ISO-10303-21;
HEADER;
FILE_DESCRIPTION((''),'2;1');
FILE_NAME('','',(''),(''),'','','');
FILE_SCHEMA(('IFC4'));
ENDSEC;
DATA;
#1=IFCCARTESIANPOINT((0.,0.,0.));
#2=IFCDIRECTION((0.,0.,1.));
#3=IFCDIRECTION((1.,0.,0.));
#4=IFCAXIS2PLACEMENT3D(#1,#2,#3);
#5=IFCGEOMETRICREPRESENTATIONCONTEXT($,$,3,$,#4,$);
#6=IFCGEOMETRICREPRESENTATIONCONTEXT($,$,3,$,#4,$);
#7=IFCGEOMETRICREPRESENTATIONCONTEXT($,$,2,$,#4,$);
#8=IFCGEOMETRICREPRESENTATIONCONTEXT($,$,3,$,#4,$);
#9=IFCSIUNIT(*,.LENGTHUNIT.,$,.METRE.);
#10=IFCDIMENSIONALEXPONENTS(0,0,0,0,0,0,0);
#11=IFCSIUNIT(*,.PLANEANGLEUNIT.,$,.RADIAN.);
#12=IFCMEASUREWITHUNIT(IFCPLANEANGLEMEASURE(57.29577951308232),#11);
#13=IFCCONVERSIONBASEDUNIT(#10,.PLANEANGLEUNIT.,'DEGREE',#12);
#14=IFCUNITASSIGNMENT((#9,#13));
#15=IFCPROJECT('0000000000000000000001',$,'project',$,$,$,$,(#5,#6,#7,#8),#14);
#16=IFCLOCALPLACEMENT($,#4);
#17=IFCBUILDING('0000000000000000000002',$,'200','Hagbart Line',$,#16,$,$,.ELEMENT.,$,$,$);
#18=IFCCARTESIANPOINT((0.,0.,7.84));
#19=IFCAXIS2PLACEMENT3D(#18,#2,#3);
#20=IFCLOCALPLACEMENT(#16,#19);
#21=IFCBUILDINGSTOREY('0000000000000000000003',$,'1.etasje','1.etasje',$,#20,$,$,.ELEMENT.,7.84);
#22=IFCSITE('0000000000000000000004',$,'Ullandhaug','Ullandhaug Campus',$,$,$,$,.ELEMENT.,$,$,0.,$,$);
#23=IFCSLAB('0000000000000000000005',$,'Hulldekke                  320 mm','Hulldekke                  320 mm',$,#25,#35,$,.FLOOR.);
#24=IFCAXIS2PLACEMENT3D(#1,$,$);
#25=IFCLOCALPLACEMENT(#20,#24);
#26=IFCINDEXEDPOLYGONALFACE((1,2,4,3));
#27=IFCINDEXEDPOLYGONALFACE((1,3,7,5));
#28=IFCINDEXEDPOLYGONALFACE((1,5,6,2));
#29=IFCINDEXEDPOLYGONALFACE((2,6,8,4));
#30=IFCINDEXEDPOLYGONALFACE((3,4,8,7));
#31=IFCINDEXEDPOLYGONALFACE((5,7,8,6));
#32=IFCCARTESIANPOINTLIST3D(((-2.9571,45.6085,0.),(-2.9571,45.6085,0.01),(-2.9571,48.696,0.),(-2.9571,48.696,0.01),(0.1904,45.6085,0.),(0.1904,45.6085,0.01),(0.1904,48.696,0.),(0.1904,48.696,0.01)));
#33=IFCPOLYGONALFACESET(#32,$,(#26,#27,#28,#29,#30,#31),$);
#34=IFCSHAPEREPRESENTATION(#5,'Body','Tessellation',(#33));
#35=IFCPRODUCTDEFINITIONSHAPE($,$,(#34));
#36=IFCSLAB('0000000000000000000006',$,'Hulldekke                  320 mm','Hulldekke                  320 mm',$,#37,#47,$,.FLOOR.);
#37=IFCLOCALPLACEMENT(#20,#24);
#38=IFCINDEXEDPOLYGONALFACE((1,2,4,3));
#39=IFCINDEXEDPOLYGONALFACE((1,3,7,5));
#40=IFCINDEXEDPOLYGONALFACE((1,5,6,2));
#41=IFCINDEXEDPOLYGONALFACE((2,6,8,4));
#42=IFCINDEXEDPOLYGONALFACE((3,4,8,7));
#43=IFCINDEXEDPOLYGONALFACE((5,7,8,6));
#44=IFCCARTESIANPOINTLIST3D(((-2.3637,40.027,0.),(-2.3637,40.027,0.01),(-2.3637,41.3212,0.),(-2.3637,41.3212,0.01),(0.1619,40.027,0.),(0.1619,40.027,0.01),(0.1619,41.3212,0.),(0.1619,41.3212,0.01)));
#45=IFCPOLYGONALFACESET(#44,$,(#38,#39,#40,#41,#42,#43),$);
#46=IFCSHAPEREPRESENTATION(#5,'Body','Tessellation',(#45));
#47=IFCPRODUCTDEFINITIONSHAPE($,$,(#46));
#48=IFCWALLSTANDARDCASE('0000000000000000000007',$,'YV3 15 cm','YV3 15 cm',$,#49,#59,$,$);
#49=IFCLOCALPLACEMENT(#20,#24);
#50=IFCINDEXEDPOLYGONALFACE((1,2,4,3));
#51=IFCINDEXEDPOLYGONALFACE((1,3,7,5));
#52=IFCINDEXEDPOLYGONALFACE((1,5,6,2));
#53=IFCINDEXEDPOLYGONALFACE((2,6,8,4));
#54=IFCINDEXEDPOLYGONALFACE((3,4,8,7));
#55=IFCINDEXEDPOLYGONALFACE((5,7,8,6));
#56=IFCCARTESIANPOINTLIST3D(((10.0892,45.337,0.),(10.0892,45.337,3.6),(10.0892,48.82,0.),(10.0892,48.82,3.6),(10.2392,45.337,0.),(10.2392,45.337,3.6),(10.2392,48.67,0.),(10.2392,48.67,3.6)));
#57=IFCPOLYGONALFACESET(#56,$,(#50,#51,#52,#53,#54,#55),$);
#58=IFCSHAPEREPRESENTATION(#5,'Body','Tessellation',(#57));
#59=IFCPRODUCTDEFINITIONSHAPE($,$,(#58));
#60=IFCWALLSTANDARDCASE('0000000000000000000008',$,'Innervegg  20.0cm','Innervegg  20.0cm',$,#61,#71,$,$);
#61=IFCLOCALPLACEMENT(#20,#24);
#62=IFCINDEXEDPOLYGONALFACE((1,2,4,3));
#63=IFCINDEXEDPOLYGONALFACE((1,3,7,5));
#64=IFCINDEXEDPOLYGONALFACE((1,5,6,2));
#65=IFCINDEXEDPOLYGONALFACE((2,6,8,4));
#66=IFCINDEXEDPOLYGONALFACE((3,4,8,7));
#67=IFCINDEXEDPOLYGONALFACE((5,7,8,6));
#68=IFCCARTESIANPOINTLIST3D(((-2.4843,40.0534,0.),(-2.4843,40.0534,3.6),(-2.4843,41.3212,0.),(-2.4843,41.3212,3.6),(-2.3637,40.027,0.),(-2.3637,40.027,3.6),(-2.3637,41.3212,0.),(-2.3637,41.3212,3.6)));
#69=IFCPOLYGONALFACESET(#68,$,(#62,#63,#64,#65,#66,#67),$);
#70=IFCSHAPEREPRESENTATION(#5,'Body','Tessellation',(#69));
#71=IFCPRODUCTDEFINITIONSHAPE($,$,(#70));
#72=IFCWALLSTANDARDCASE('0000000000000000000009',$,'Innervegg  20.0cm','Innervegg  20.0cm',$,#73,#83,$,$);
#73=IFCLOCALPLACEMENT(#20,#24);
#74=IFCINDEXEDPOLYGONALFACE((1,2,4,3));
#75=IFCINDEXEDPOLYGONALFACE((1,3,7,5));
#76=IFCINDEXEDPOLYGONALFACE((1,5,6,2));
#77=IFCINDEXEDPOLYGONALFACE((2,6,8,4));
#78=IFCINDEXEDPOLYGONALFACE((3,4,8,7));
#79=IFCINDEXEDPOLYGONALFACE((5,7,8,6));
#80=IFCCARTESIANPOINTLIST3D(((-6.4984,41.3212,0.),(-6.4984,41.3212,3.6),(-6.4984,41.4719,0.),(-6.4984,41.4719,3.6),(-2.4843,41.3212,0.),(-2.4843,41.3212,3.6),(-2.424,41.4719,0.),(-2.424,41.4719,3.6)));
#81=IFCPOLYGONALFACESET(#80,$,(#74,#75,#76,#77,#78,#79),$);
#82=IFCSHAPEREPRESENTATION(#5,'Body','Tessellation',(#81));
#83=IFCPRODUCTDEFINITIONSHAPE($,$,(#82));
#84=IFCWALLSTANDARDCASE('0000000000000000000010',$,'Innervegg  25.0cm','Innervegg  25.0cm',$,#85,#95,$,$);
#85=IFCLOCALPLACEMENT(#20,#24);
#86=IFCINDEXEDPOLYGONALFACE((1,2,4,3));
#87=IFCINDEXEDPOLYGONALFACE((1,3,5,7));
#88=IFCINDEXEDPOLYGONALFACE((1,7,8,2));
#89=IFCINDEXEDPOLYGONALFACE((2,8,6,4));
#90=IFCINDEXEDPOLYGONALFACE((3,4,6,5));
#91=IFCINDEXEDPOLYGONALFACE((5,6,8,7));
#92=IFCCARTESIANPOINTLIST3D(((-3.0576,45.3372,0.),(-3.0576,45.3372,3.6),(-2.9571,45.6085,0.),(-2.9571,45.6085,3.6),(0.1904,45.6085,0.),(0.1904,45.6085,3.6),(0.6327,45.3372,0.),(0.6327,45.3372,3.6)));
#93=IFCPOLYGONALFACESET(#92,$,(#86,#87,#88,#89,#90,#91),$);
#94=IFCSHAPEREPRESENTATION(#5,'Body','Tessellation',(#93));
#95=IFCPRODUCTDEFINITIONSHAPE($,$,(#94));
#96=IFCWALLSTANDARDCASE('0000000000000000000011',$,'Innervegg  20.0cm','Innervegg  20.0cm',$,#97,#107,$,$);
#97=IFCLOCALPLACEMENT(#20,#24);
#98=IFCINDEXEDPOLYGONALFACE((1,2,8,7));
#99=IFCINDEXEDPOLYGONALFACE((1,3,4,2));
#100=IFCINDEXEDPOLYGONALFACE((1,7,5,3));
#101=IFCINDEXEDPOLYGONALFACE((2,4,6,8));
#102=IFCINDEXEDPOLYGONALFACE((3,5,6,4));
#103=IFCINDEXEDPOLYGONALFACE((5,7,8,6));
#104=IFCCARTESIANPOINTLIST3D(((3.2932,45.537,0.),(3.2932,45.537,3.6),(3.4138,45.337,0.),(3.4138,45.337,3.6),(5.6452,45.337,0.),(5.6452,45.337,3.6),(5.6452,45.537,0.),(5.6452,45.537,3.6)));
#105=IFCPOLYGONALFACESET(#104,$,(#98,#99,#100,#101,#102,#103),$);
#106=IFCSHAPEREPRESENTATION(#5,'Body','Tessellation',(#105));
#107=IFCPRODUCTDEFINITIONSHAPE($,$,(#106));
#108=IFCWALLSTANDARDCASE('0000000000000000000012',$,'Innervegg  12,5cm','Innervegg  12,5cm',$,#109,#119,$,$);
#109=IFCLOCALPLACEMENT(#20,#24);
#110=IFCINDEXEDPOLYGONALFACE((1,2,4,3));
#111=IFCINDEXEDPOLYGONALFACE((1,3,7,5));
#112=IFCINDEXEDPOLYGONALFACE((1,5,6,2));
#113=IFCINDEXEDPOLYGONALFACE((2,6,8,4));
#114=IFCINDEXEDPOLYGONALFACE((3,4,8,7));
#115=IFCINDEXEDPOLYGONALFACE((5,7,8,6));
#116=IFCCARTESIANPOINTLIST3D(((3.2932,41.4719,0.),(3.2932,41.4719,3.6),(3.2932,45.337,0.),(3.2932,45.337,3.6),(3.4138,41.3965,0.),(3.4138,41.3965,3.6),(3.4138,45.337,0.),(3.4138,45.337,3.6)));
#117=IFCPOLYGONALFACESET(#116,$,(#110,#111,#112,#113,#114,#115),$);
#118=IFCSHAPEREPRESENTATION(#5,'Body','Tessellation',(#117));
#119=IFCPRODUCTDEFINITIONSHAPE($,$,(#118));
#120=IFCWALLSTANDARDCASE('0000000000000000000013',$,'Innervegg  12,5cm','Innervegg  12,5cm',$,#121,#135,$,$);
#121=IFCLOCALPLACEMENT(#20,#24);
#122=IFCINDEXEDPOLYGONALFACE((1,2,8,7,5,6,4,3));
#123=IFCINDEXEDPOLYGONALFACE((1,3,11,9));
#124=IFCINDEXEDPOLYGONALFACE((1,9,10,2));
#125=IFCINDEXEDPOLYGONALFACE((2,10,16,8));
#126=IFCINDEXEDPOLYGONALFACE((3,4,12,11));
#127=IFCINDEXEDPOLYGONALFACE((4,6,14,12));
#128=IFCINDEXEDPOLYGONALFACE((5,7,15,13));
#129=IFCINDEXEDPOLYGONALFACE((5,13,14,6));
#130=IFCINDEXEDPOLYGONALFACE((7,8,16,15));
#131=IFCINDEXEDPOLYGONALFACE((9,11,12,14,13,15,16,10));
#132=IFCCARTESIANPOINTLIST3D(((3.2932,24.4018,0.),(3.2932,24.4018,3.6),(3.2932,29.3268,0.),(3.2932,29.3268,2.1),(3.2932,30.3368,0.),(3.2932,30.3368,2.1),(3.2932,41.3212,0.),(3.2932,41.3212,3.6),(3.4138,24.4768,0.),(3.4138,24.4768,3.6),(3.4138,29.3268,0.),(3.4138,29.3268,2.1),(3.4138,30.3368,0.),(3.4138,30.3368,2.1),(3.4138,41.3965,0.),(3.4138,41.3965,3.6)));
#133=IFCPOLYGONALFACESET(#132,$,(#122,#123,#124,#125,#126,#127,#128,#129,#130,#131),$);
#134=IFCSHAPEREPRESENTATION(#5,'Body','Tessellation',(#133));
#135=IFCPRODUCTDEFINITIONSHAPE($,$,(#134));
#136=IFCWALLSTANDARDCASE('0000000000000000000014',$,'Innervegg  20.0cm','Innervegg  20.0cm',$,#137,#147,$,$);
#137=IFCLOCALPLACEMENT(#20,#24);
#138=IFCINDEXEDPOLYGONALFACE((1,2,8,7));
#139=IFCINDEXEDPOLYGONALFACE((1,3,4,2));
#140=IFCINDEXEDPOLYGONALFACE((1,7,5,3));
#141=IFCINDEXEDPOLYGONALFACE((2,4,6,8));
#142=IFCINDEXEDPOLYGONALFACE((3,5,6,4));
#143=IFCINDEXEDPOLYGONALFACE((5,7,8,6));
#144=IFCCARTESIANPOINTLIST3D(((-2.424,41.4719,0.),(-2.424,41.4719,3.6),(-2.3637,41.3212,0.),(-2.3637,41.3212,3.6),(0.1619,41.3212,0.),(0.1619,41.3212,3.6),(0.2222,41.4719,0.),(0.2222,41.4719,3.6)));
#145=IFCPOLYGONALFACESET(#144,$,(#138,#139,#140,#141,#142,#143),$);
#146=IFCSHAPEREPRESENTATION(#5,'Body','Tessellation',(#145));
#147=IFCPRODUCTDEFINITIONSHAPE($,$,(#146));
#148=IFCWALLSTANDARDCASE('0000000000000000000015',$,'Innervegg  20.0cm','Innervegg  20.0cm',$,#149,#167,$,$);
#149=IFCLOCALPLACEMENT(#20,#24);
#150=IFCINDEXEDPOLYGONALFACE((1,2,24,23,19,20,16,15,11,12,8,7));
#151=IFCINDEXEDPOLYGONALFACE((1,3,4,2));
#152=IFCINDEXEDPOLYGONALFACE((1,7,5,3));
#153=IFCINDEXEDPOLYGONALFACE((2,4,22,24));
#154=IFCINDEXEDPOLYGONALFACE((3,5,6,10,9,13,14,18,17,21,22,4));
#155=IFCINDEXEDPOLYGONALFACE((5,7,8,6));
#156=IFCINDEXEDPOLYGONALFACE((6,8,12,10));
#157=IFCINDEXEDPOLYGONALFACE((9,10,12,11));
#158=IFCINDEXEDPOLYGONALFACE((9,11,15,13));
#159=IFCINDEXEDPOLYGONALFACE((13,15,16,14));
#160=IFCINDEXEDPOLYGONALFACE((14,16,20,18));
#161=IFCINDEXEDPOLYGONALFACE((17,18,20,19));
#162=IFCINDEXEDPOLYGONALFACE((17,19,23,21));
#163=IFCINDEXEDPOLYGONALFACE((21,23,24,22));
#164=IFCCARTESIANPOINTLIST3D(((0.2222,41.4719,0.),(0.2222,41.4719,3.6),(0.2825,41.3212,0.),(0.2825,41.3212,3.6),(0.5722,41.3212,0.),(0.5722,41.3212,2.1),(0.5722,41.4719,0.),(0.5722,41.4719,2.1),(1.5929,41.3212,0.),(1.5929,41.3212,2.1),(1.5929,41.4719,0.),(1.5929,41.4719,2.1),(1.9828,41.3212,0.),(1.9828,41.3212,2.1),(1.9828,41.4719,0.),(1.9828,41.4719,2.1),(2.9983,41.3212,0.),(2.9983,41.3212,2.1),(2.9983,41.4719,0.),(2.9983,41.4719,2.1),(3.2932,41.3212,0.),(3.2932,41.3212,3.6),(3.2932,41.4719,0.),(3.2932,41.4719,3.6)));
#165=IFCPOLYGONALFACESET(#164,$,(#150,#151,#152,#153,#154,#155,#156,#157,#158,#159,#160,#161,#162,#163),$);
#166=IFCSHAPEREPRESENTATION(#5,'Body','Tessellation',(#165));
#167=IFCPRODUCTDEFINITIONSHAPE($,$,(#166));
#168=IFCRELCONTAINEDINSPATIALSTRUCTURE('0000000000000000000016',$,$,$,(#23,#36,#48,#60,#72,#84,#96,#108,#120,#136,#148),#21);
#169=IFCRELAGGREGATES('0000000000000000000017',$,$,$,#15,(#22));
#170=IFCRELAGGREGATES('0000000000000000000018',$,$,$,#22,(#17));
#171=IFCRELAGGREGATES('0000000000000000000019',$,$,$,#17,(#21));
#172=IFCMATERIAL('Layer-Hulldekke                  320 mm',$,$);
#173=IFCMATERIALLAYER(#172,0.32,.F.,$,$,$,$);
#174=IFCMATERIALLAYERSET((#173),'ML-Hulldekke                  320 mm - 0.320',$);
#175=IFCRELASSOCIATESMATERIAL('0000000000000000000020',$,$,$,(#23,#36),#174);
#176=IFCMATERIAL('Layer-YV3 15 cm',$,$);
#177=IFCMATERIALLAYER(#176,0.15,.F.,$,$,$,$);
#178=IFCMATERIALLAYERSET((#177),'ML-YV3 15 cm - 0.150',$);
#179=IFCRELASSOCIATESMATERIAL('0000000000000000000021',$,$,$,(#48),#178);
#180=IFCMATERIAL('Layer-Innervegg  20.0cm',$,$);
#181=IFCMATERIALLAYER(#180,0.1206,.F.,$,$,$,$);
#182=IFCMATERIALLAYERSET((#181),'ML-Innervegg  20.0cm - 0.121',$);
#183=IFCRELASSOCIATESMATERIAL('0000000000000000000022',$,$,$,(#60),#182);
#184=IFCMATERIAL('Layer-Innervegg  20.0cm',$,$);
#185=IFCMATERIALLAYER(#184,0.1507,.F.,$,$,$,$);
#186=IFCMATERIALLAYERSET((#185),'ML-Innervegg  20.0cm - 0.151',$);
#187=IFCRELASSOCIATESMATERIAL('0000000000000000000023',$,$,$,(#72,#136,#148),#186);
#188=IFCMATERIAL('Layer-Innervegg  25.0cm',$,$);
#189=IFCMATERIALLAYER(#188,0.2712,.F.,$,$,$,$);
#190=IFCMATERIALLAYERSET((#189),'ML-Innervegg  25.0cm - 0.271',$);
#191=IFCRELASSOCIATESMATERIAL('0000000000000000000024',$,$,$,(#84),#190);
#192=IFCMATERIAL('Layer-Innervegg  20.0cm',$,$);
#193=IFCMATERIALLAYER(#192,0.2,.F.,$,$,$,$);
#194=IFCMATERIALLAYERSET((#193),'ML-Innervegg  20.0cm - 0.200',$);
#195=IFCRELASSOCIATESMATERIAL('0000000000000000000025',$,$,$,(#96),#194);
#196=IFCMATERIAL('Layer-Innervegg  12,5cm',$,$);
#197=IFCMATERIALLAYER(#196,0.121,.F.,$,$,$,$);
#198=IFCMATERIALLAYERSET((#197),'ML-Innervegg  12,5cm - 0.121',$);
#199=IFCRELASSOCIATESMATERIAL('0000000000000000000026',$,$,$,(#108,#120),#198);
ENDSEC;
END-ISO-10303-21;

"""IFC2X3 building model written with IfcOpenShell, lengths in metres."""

from ifc_helpers import new_model, entity, si_unit, converted_unit, frame, origin_with_axes, place, context, project, spatial, polyline, outline, extrude, material, layer, layer_set, layer_usage, element, save


model = new_model("IFC2X3")

# Units and contexts
context_of_model_1 = context(None, 3, world=origin_with_axes())
context_of_model_2 = context(None, 3, world=origin_with_axes())
context_of_model_3 = context(None, 2, world=origin_with_axes())
context_of_model_4 = context(None, 3, world=origin_with_axes())
ifc_project = project(units=[si_unit("LENGTHUNIT", "METRE"), converted_unit("PLANEANGLEUNIT", "DEGREE", entity("IfcPlaneAngleMeasure", 57.29577951308232), si_unit("PLANEANGLEUNIT", "RADIAN"), dimensions=[0, 0, 0, 0, 0, 0, 0])], contexts=[context_of_model_1, context_of_model_2, context_of_model_3, context_of_model_4])

# Site, building, storey
site = spatial("IfcSite", under=ifc_project, Name="Ullandhaug", Description="Ullandhaug Campus", CompositionType="ELEMENT", RefElevation=0.0)
building_placement = place(None, origin_with_axes())
building = spatial("IfcBuilding", under=site, at=building_placement, Name="200", Description="Hagbart Line", CompositionType="ELEMENT")
storey_placement = place(building_placement, frame((0.0, 0.0, 7.84), z_axis=(0.0, 0.0, 1.0), x_axis=(1.0, 0.0, 0.0)))
storey = spatial("IfcBuildingStorey", under=building, at=storey_placement, Name="1.etasje", Description="1.etasje", CompositionType="ELEMENT", Elevation=7.84)

# Slabs
ifc_material_1 = material(Name="Layer-Hulldekke                  320 mm")
ifc_layer_1 = layer(ifc_material_1, 0.32, ventilated=False)
ifc_layer_set_1 = layer_set([ifc_layer_1], Name="ML-Hulldekke                  320 mm - 0.320")
ifc_layer_usage_1 = layer_usage(ifc_layer_set_1, "AXIS2", "POSITIVE", 0.0)
slab_1_placement = place(storey_placement, frame((-2.9571, 45.6085, 0.0), z_axis=(0.0, 0.0, 1.0), x_axis=(1.0, 0.0, 0.0)))
element("IfcSlab", 1, at=slab_1_placement, inside=storey, material=ifc_layer_usage_1, Name="Hulldekke                  320 mm", Description="Hulldekke                  320 mm", PredefinedType="FLOOR", context=context_of_model_1, shape_type="SweptSolid", body=[
    extrude(outline(polyline([(0.0, 0.0), (3.1475, 0.0), (3.1475, 3.0875), (0.0, 3.0875), (0.0, 0.0)])), origin_with_axes(), (0.0, 0.0, 1.0), 0.01),
])
slab_2_placement = place(storey_placement, frame((-2.3637, 40.027, 0.0), z_axis=(0.0, 0.0, 1.0), x_axis=(1.0, 0.0, 0.0)))
element("IfcSlab", 2, at=slab_2_placement, inside=storey, material=ifc_layer_usage_1, Name="Hulldekke                  320 mm", Description="Hulldekke                  320 mm", PredefinedType="FLOOR", context=context_of_model_1, shape_type="SweptSolid", body=[
    extrude(outline(polyline([(0.0, 0.0), (2.5256, 0.0), (2.5256, 1.2942), (0.0, 1.2942), (0.0, 0.0)])), origin_with_axes(), (0.0, 0.0, 1.0), 0.01),
])

# Walls
ifc_material_2 = material(Name="Layer-YV3 15 cm")
ifc_layer_2 = layer(ifc_material_2, 0.15, ventilated=False)
ifc_layer_set_2 = layer_set([ifc_layer_2], Name="ML-YV3 15 cm - 0.150")
ifc_layer_usage_2 = layer_usage(ifc_layer_set_2, "AXIS2", "POSITIVE", 0.0)
wall_1_placement = place(storey_placement, frame((10.2392, 45.337, 0.0), z_axis=(0.0, 0.0, 1.0), x_axis=(0.0, 1.0, 0.0)))
element("IfcWallStandardCase", 3, at=wall_1_placement, inside=storey, material=ifc_layer_usage_2, Name="YV3 15 cm", Description="YV3 15 cm", context=context_of_model_1, shape_type="SweptSolid", body=[
    extrude(outline(polyline([(0.0, 0.0), (3.333, 0.0), (3.483, 0.15), (0.0, 0.15), (0.0, 0.0)])), frame((0.0, 0.0, 0.0), z_axis=(0.0, 0.0, 1.0), x_axis=(1.0, 0.0, 0.0)), (0.0, 0.0, 1.0), 3.6),
])
ifc_material_3 = material(Name="Layer-Innervegg  20.0cm")
ifc_layer_3 = layer(ifc_material_3, 0.1206, ventilated=False)
ifc_layer_set_3 = layer_set([ifc_layer_3], Name="ML-Innervegg  20.0cm - 0.121")
ifc_layer_usage_3 = layer_usage(ifc_layer_set_3, "AXIS2", "POSITIVE", 0.0)
wall_2_placement = place(storey_placement, frame((-2.3637, 40.027, 0.0), z_axis=(0.0, 0.0, 1.0), x_axis=(0.0, 1.0, 0.0)))
element("IfcWallStandardCase", 4, at=wall_2_placement, inside=storey, material=ifc_layer_usage_3, Name="Innervegg  20.0cm", Description="Innervegg  20.0cm", context=context_of_model_1, shape_type="SweptSolid", body=[
    extrude(outline(polyline([(0.0, 0.0), (1.2942, 0.0), (1.2942, 0.1206), (0.0264, 0.1206), (0.0, 0.0)])), frame((0.0, 0.0, 0.0), z_axis=(0.0, 0.0, 1.0), x_axis=(1.0, 0.0, 0.0)), (0.0, 0.0, 1.0), 3.6),
])
ifc_material_4 = material(Name="Layer-Innervegg  20.0cm")
ifc_layer_4 = layer(ifc_material_4, 0.1507, ventilated=False)
ifc_layer_set_4 = layer_set([ifc_layer_4], Name="ML-Innervegg  20.0cm - 0.151")
ifc_layer_usage_4 = layer_usage(ifc_layer_set_4, "AXIS2", "POSITIVE", 0.0)
wall_3_placement = place(storey_placement, frame((-2.424, 41.4719, 0.0), z_axis=(0.0, 0.0, 1.0), x_axis=(-1.0, 0.0, 0.0)))
element("IfcWallStandardCase", 5, at=wall_3_placement, inside=storey, material=ifc_layer_usage_4, Name="Innervegg  20.0cm", Description="Innervegg  20.0cm", context=context_of_model_1, shape_type="SweptSolid", body=[
    extrude(outline(polyline([(0.0, 0.0), (4.0744, 0.0), (4.0744, 0.1507), (0.0603, 0.1507), (0.0, 0.0)])), frame((0.0, 0.0, 0.0), z_axis=(0.0, 0.0, 1.0), x_axis=(1.0, 0.0, 0.0)), (0.0, 0.0, 1.0), 3.6),
])
ifc_material_5 = material(Name="Layer-Innervegg  25.0cm")
ifc_layer_5 = layer(ifc_material_5, 0.2712, ventilated=False)
ifc_layer_set_5 = layer_set([ifc_layer_5], Name="ML-Innervegg  25.0cm - 0.271")
ifc_layer_usage_5 = layer_usage(ifc_layer_set_5, "AXIS2", "POSITIVE", 0.0)
wall_4_placement = place(storey_placement, frame((-3.0576, 45.3372, 0.0), z_axis=(0.0, 0.0, 1.0), x_axis=(1.0, 0.0, 0.0)))
element("IfcWallStandardCase", 6, at=wall_4_placement, inside=storey, material=ifc_layer_usage_5, Name="Innervegg  25.0cm", Description="Innervegg  25.0cm", context=context_of_model_1, shape_type="SweptSolid", body=[
    extrude(outline(polyline([(0.0, 0.0), (3.6903, 0.0), (3.248, 0.2712), (0.1005, 0.2712), (0.0, 0.0)])), origin_with_axes(), (0.0, 0.0, 1.0), 3.6),
])
ifc_material_6 = material(Name="Layer-Innervegg  20.0cm")
ifc_layer_6 = layer(ifc_material_6, 0.2, ventilated=False)
ifc_layer_set_6 = layer_set([ifc_layer_6], Name="ML-Innervegg  20.0cm - 0.200")
ifc_layer_usage_6 = layer_usage(ifc_layer_set_6, "AXIS2", "POSITIVE", 0.0)
wall_5_placement = place(storey_placement, frame((5.6452, 45.537, 0.0), z_axis=(0.0, 0.0, 1.0), x_axis=(-1.0, 0.0, 0.0)))
element("IfcWallStandardCase", 7, at=wall_5_placement, inside=storey, material=ifc_layer_usage_6, Name="Innervegg  20.0cm", Description="Innervegg  20.0cm", context=context_of_model_1, shape_type="SweptSolid", body=[
    extrude(outline(polyline([(0.0, 0.0), (2.3521, 0.0), (2.2315, 0.2), (0.0, 0.2), (0.0, 0.0)])), frame((0.0, 0.0, 0.0), z_axis=(0.0, 0.0, 1.0), x_axis=(1.0, 0.0, 0.0)), (0.0, 0.0, 1.0), 3.6),
])
ifc_material_7 = material(Name="Layer-Innervegg  12,5cm")
ifc_layer_7 = layer(ifc_material_7, 0.121, ventilated=False)
ifc_layer_set_7 = layer_set([ifc_layer_7], Name="ML-Innervegg  12,5cm - 0.121")
ifc_layer_usage_7 = layer_usage(ifc_layer_set_7, "AXIS2", "POSITIVE", 0.0)
wall_6_placement = place(storey_placement, frame((3.2932, 45.337, 0.0), z_axis=(0.0, 0.0, 1.0), x_axis=(0.0, -1.0, 0.0)))
element("IfcWallStandardCase", 8, at=wall_6_placement, inside=storey, material=ifc_layer_usage_7, Name="Innervegg  12,5cm", Description="Innervegg  12,5cm", context=context_of_model_1, shape_type="SweptSolid", body=[
    extrude(outline(polyline([(0.0, 0.0), (3.8651, 0.0), (3.9404, 0.1206), (0.0, 0.1206), (0.0, 0.0)])), frame((0.0, 0.0, 0.0), z_axis=(0.0, 0.0, 1.0), x_axis=(1.0, 0.0, 0.0)), (0.0, 0.0, 1.0), 3.6),
])

# Wall, opening
wall_7_placement = place(storey_placement, frame((3.2932, 41.3212, 0.0), z_axis=(0.0, 0.0, 1.0), x_axis=(0.0, -1.0, 0.0)))
wall_7 = element("IfcWallStandardCase", 9, at=wall_7_placement, inside=storey, material=ifc_layer_usage_7, Name="Innervegg  12,5cm", Description="Innervegg  12,5cm", context=context_of_model_1, shape_type="SweptSolid", body=[
    extrude(outline(polyline([(0.0, 0.0), (16.9193, 0.0), (16.8444, 0.1206), (-0.0754, 0.1206), (0.0, 0.0)])), frame((0.0, 0.0, 0.0), z_axis=(0.0, 0.0, 1.0), x_axis=(1.0, 0.0, 0.0)), (0.0, 0.0, 1.0), 3.6),
])
opening_1_placement = place(wall_7_placement, frame((10.9843, 0.1206, 0.0), z_axis=(0.0, 0.0, 1.0), x_axis=(1.0, 0.0, 0.0)))
element("IfcOpeningElement", 10, at=opening_1_placement, cuts=wall_7, context=context_of_model_1, shape_type="SweptSolid", body=[
    extrude(outline(polyline([(0.0, 0.0), (2.1, 0.0), (2.1, 1.01), (0.0, 1.01), (0.0, 0.0)])), frame((0.0, 0.0, 0.0), z_axis=(0.0, 1.0, 0.0), x_axis=(0.0, 0.0, 1.0)), (0.0, 0.0, -1.0), 0.1206),
])

# Wall
wall_8_placement = place(storey_placement, frame((-2.3637, 41.3212, 0.0), z_axis=(0.0, 0.0, 1.0), x_axis=(1.0, 0.0, 0.0)))
element("IfcWallStandardCase", 11, at=wall_8_placement, inside=storey, material=ifc_layer_usage_4, Name="Innervegg  20.0cm", Description="Innervegg  20.0cm", context=context_of_model_1, shape_type="SweptSolid", body=[
    extrude(outline(polyline([(0.0, 0.0), (2.5256, 0.0), (2.5859, 0.1507), (-0.0603, 0.1507), (0.0, 0.0)])), origin_with_axes(), (0.0, 0.0, 1.0), 3.6),
])

# Wall, openings
wall_9_placement = place(storey_placement, frame((0.2825, 41.3212, 0.0), z_axis=(0.0, 0.0, 1.0), x_axis=(1.0, 0.0, 0.0)))
wall_9 = element("IfcWallStandardCase", 12, at=wall_9_placement, inside=storey, material=ifc_layer_usage_4, Name="Innervegg  20.0cm", Description="Innervegg  20.0cm", context=context_of_model_1, shape_type="SweptSolid", body=[
    extrude(outline(polyline([(0.0, 0.0), (3.0107, 0.0), (3.0107, 0.1507), (-0.0603, 0.1507), (0.0, 0.0)])), origin_with_axes(), (0.0, 0.0, 1.0), 3.6),
])
opening_2_placement = place(wall_9_placement, frame((1.7004, 0.1507, 0.0), z_axis=(0.0, 0.0, 1.0), x_axis=(1.0, 0.0, 0.0)))
element("IfcOpeningElement", 13, at=opening_2_placement, cuts=wall_9, context=context_of_model_1, shape_type="SweptSolid", body=[
    extrude(outline(polyline([(0.0, 0.0), (2.1, 0.0), (2.1, 1.0155), (0.0, 1.0155), (0.0, 0.0)])), frame((0.0, 0.0, 0.0), z_axis=(0.0, 1.0, 0.0), x_axis=(0.0, 0.0, 1.0)), (0.0, 0.0, -1.0), 0.1507),
])
opening_3_placement = place(wall_9_placement, frame((0.2897, 0.1507, 0.0), z_axis=(0.0, 0.0, 1.0), x_axis=(1.0, 0.0, 0.0)))
element("IfcOpeningElement", 14, at=opening_3_placement, cuts=wall_9, context=context_of_model_1, shape_type="SweptSolid", body=[
    extrude(outline(polyline([(0.0, 0.0), (2.1, 0.0), (2.1, 1.0207), (0.0, 1.0207), (0.0, 0.0)])), frame((0.0, 0.0, 0.0), z_axis=(0.0, 1.0, 0.0), x_axis=(0.0, 0.0, 1.0)), (0.0, 0.0, -1.0), 0.1507),
])

save(model, "model.ifc")
